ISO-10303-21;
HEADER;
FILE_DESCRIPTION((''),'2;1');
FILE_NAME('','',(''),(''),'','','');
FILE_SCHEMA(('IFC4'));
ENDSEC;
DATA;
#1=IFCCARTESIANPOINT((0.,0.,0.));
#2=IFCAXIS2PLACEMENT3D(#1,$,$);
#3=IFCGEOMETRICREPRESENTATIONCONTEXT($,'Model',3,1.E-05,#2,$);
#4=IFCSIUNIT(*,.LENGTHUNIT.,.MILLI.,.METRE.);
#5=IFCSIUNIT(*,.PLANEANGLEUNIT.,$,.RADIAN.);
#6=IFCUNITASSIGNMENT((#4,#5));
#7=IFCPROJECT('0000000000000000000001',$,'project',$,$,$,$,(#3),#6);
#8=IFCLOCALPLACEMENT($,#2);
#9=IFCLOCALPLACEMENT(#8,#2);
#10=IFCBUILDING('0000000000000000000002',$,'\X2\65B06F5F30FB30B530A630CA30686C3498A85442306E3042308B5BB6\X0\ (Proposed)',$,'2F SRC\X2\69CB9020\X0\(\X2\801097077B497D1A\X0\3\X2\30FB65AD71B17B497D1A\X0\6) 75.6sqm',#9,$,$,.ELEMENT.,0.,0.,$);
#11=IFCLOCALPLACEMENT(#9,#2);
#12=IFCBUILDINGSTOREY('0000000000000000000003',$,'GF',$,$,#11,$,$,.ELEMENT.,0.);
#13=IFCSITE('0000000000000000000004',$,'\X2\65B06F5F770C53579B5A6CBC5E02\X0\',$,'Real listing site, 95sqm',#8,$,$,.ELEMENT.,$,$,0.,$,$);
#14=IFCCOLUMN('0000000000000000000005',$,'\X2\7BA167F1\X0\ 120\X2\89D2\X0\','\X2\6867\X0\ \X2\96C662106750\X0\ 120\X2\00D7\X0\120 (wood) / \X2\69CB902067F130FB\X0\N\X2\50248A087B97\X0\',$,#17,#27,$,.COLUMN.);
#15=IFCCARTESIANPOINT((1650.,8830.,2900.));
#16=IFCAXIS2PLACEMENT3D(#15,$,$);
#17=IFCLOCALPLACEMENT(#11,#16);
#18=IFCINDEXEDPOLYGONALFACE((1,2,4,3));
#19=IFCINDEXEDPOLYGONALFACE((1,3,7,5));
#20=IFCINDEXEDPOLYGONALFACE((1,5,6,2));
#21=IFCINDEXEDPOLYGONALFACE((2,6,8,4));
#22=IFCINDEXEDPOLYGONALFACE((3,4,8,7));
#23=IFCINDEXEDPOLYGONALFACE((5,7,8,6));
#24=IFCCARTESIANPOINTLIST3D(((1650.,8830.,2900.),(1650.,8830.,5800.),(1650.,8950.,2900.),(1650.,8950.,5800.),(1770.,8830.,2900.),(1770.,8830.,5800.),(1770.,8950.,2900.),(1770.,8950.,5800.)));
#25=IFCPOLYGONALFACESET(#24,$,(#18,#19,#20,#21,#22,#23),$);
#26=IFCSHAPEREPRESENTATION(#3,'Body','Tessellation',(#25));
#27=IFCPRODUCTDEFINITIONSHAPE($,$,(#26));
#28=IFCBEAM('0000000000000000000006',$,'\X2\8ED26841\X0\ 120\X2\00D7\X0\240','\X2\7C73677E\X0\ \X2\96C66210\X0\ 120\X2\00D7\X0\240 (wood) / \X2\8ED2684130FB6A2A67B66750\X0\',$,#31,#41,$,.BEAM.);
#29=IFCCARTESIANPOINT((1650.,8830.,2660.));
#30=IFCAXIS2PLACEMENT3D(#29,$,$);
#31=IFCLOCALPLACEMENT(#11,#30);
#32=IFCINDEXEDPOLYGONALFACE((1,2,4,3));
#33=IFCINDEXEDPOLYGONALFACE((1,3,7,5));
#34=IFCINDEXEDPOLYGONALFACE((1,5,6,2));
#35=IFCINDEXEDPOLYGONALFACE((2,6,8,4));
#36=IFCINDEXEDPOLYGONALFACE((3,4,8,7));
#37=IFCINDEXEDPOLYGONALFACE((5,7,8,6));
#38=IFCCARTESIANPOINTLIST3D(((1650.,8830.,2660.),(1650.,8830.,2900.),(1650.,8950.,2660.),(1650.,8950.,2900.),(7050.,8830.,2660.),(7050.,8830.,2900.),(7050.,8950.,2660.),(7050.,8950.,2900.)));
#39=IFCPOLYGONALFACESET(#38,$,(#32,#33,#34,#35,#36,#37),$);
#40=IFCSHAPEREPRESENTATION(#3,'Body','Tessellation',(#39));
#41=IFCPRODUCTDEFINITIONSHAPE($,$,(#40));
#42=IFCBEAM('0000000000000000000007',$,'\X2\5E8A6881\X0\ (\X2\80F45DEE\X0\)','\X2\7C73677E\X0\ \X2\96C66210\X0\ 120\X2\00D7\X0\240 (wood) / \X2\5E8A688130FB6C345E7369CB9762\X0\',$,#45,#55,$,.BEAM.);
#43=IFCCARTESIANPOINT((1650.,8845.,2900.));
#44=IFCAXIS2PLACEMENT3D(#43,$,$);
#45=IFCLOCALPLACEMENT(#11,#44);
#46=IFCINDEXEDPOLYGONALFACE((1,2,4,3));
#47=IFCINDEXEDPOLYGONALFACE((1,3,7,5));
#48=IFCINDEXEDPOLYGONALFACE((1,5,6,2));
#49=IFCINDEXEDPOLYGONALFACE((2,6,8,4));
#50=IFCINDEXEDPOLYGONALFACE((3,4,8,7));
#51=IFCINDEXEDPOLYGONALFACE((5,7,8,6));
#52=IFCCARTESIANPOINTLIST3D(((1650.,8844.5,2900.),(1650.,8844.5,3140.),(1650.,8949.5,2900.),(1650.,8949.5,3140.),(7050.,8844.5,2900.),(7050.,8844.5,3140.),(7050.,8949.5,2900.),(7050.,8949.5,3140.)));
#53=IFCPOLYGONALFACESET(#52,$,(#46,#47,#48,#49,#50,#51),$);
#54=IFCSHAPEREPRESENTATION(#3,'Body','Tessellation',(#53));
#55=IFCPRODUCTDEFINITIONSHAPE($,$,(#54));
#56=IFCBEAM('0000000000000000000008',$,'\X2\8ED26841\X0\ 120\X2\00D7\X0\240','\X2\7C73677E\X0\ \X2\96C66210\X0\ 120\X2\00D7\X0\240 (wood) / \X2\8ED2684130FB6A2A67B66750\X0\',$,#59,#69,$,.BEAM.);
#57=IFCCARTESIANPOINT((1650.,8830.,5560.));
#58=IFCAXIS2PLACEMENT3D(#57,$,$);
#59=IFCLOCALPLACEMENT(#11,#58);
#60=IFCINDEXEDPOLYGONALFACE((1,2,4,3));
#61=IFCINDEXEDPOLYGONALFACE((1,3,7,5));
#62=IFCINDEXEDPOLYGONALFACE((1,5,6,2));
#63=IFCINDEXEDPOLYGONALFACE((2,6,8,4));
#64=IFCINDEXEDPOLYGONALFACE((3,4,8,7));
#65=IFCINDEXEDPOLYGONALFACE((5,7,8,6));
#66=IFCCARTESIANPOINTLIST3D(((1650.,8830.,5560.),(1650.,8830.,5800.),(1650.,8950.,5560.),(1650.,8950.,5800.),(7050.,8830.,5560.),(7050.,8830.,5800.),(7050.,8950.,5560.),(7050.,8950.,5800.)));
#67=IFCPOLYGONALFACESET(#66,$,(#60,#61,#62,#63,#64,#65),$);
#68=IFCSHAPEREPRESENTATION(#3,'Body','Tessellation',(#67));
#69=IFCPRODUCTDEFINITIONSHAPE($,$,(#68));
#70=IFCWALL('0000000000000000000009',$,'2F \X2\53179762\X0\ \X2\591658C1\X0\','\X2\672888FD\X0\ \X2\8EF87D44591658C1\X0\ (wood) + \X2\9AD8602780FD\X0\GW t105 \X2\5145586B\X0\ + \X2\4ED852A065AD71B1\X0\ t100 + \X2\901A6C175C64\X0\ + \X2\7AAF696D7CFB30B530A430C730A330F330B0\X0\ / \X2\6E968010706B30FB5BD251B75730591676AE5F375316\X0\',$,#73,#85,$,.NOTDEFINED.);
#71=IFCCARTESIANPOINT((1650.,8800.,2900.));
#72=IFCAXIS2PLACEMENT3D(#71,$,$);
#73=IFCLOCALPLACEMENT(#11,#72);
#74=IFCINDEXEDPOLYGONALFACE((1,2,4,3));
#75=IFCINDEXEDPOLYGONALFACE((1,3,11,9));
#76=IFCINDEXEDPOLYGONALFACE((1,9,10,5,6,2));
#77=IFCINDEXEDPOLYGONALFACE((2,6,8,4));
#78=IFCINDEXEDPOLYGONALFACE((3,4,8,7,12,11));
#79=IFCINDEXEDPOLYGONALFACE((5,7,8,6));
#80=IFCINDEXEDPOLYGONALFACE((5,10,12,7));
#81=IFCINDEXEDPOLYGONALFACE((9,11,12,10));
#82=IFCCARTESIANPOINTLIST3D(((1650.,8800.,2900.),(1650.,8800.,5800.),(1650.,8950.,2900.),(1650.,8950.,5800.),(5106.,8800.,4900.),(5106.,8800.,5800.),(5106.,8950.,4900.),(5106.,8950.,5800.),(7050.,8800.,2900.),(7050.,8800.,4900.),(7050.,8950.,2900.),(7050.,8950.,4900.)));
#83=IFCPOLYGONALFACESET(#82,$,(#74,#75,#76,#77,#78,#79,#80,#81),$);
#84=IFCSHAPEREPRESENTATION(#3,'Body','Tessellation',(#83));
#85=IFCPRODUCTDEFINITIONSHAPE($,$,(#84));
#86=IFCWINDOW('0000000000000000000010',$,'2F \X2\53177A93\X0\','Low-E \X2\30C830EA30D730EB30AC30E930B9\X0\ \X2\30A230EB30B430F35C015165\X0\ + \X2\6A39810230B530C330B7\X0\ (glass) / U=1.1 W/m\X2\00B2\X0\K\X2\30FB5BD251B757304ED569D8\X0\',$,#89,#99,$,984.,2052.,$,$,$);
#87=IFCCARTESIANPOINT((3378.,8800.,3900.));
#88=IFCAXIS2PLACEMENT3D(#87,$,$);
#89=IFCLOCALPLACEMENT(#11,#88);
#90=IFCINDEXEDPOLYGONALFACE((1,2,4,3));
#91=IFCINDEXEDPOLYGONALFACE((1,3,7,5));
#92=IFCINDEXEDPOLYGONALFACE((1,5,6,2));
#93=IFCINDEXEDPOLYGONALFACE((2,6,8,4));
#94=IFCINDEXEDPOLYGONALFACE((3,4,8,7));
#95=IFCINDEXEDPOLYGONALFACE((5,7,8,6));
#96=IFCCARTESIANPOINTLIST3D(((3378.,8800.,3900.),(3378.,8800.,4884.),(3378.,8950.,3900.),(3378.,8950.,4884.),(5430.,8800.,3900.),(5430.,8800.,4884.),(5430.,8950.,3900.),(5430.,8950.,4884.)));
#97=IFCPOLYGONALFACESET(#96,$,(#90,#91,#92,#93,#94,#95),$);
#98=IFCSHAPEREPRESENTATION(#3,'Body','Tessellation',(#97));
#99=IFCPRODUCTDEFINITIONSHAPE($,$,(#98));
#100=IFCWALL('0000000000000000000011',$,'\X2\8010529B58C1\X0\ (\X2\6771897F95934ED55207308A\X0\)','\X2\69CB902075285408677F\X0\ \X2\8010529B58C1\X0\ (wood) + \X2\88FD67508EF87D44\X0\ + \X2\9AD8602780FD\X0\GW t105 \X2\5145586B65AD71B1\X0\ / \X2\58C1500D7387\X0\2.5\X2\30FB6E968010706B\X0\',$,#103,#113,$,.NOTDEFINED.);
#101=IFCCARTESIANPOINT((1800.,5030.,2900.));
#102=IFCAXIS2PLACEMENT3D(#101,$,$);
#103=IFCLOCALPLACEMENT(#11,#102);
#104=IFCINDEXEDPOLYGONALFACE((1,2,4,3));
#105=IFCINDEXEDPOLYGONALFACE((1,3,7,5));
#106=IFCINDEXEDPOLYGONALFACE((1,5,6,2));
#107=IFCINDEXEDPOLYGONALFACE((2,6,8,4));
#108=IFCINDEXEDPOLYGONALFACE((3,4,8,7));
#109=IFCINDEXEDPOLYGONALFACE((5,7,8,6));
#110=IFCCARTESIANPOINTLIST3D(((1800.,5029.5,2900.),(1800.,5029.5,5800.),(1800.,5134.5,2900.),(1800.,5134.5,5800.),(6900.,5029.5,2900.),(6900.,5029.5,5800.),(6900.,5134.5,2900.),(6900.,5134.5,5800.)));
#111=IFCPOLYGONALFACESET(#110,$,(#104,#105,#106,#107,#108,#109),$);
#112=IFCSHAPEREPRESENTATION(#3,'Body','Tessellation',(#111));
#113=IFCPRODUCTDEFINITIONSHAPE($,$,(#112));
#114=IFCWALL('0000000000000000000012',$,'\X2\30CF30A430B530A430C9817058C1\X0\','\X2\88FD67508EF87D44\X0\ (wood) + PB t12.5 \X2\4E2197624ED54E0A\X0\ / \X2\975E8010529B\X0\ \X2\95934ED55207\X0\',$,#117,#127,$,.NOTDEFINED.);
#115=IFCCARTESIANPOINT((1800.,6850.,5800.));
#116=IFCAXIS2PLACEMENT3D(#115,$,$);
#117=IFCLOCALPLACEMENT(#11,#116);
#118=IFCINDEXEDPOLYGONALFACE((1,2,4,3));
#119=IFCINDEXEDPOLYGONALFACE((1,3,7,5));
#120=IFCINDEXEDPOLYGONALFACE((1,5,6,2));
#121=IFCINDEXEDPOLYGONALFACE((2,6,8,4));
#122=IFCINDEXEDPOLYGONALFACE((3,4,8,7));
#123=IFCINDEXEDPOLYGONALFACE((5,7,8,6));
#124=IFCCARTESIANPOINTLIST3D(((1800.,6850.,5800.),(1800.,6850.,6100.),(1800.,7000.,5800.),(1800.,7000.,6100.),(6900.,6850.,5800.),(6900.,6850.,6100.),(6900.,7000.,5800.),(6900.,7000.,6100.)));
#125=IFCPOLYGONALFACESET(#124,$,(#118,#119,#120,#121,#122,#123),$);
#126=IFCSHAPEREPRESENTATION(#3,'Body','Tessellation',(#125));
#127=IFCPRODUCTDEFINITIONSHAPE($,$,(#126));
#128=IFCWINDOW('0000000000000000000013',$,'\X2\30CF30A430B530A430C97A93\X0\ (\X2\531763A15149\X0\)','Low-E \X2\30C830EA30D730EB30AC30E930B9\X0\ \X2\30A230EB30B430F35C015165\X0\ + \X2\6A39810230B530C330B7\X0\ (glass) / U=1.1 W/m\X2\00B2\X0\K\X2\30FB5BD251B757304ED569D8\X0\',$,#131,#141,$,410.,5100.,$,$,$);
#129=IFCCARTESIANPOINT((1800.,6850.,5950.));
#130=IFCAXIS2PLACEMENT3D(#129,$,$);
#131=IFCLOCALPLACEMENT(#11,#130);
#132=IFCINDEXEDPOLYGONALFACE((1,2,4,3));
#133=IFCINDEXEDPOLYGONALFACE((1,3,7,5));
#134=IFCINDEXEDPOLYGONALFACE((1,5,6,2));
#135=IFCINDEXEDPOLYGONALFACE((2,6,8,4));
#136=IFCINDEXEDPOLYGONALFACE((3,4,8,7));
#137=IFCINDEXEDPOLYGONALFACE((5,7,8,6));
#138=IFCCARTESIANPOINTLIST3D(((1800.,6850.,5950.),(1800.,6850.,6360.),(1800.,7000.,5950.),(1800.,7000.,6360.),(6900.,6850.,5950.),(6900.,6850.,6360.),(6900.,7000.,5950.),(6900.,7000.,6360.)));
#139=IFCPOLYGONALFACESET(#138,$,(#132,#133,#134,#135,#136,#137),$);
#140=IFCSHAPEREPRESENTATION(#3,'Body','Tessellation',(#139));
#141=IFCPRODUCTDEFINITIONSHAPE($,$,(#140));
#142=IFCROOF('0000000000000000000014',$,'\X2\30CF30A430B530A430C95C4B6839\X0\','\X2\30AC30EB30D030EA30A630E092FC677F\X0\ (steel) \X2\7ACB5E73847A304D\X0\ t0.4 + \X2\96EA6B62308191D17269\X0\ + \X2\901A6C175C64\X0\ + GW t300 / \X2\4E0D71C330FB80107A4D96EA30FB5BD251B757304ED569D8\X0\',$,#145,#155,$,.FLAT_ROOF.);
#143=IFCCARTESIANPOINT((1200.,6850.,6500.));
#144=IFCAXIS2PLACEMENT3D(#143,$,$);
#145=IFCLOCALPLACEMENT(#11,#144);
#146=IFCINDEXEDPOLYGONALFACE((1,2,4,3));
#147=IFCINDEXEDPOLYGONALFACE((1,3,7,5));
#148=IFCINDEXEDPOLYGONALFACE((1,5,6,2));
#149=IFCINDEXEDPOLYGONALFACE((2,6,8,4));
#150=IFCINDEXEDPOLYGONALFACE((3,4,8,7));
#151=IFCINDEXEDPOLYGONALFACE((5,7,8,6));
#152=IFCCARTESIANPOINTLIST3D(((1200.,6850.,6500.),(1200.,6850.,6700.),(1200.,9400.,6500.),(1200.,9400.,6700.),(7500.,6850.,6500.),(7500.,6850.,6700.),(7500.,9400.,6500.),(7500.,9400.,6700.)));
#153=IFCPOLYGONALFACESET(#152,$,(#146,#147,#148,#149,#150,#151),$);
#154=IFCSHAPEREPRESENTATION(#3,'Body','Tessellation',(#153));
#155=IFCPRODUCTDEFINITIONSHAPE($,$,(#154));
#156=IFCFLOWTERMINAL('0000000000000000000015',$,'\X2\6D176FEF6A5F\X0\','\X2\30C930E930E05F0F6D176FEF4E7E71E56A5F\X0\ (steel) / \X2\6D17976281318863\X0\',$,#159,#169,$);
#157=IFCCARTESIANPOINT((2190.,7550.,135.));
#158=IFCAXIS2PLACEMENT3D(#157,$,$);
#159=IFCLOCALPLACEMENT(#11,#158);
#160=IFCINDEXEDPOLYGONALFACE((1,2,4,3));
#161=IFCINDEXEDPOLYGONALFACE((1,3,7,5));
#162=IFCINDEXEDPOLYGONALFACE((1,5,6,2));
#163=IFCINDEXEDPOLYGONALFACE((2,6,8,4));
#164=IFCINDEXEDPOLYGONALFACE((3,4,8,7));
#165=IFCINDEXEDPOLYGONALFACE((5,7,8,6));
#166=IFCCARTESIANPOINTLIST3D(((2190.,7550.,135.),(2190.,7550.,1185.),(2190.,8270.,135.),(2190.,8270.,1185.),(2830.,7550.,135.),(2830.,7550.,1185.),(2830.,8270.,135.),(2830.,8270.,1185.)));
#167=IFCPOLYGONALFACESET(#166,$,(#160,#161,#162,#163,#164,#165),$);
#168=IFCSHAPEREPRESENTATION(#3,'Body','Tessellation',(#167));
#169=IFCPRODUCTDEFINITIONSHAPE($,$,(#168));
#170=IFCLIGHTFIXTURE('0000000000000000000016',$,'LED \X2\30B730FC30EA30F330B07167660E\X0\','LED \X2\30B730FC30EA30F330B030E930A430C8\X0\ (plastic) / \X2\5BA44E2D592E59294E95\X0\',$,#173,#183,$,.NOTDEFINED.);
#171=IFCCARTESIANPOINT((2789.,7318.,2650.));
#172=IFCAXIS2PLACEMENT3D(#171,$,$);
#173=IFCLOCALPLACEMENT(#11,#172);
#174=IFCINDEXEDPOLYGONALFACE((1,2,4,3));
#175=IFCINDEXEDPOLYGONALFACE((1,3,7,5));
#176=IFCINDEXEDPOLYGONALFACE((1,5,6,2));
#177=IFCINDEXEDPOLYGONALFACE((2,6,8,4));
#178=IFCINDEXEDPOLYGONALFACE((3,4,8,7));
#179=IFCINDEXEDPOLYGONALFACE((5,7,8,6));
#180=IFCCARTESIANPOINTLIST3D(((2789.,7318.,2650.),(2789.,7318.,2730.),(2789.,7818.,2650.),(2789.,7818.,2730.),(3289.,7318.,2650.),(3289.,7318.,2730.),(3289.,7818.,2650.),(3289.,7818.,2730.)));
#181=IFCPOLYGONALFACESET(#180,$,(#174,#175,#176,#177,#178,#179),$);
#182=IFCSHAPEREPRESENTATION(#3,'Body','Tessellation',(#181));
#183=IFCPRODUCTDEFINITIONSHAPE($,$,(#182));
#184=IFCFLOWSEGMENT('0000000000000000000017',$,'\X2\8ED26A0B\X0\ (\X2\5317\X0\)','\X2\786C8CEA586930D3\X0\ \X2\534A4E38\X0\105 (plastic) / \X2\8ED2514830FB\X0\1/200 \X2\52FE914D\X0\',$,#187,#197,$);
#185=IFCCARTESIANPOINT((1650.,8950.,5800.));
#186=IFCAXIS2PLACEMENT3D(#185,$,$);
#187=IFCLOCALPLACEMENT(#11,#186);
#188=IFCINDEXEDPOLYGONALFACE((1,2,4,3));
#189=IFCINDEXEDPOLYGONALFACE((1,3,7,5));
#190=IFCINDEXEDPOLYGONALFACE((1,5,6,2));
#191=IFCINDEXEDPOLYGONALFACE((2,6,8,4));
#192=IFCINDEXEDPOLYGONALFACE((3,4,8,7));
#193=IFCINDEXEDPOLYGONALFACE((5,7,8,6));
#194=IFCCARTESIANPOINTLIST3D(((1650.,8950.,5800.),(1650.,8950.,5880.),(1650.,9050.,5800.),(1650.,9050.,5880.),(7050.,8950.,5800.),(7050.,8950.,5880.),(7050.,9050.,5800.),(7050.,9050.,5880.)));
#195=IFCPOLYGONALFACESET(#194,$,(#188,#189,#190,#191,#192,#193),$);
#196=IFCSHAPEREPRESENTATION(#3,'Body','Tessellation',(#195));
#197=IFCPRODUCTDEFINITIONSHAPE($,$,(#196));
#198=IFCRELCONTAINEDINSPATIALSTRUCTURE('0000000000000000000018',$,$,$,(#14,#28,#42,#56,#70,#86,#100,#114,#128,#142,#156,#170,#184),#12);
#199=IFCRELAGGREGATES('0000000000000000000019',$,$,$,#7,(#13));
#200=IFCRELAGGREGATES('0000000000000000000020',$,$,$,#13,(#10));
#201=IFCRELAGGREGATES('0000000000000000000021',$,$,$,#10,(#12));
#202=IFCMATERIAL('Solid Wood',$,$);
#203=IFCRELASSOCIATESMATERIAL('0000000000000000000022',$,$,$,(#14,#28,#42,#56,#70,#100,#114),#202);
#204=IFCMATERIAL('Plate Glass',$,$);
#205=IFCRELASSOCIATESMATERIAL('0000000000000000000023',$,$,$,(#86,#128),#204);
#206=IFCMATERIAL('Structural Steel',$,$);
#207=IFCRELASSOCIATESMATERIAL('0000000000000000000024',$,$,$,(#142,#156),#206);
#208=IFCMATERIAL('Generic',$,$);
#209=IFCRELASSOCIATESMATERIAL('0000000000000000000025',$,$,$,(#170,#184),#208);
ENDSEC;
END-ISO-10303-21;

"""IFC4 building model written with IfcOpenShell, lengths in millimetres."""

from ifc_helpers import new_model, si_unit, frame, frame_2d, origin, place, context, project, spatial, rectangle, extrude, material, element, fill, save


model = new_model("IFC4")

# Units and contexts
model_context = context("Model", 3, precision=1e-05, world=origin())
ifc_project = project(units=[si_unit("LENGTHUNIT", "METRE", prefix="MILLI"), si_unit("PLANEANGLEUNIT", "RADIAN")], contexts=[model_context])

# Site, building, storey
site_placement = place(None, origin())
site = spatial("IfcSite", under=ifc_project, at=site_placement, Name="新潟県南魚沼市", ObjectType="Real listing site, 95sqm", CompositionType="ELEMENT", RefElevation=0.0)
building_placement = place(site_placement, origin())
building = spatial("IfcBuilding", under=site, at=building_placement, Name="新潟・サウナと水風呂のある家 (Proposed)", ObjectType="2F SRC構造(耐震等級3・断熱等級6) 75.6sqm", CompositionType="ELEMENT", ElevationOfRefHeight=0.0, ElevationOfTerrain=0.0)
storey_placement = place(building_placement, origin())
storey = spatial("IfcBuildingStorey", under=building, at=storey_placement, Name="GF", CompositionType="ELEMENT", Elevation=0.0)

# Column
ifc_material_1 = material(Name="Solid Wood")
column_1_placement = place(storey_placement, frame((1650.0, 8830.0, 2900.0)))
element("IfcColumn", 1, at=column_1_placement, inside=storey, material=ifc_material_1, Name="管柱 120角", Description="桧 集成材 120×120 (wood) / 構造柱・N値計算", PredefinedType="COLUMN", context=model_context, shape_type="SweptSolid", body=[
    extrude(rectangle(XDim=120.0, YDim=120.0, at=frame_2d((60.0, 60.0))), frame((1650.0, 8830.0, 2900.0)), (0.0, 0.0, 1.0), 2900.0),
])

# Beams
beam_1_placement = place(storey_placement, frame((1650.0, 8830.0, 2660.0)))
element("IfcBeam", 2, at=beam_1_placement, inside=storey, material=ifc_material_1, Name="軒桁 120×240", Description="米松 集成 120×240 (wood) / 軒桁・横架材", PredefinedType="BEAM", context=model_context, shape_type="SweptSolid", body=[
    extrude(rectangle(XDim=5400.0, YDim=120.0, at=frame_2d((2700.0, 60.0))), frame((1650.0, 8830.0, 2660.0)), (0.0, 0.0, 1.0), 240.0),
])
beam_2_placement = place(storey_placement, frame((1650.0, 8845.0, 2900.0)))
element("IfcBeam", 3, at=beam_2_placement, inside=storey, material=ifc_material_1, Name="床梁 (胴差)", Description="米松 集成 120×240 (wood) / 床梁・水平構面", PredefinedType="BEAM", context=model_context, shape_type="SweptSolid", body=[
    extrude(rectangle(XDim=5400.0, YDim=105.0, at=frame_2d((2700.0, 52.0))), frame((1650.0, 8845.0, 2900.0)), (0.0, 0.0, 1.0), 240.0),
])
beam_3_placement = place(storey_placement, frame((1650.0, 8830.0, 5560.0)))
element("IfcBeam", 4, at=beam_3_placement, inside=storey, material=ifc_material_1, Name="軒桁 120×240", Description="米松 集成 120×240 (wood) / 軒桁・横架材", PredefinedType="BEAM", context=model_context, shape_type="SweptSolid", body=[
    extrude(rectangle(XDim=5400.0, YDim=120.0, at=frame_2d((2700.0, 60.0))), frame((1650.0, 8830.0, 5560.0)), (0.0, 0.0, 1.0), 240.0),
])

# Wall, opening, window
wall_1_placement = place(storey_placement, frame((1650.0, 8800.0, 2900.0)))
wall_1 = element("IfcWall", 5, at=wall_1_placement, inside=storey, material=ifc_material_1, Name="2F 北面 外壁", Description="木製 軸組外壁 (wood) + 高性能GW t105 充填 + 付加断熱 t100 + 通気層 + 窯業系サイディング / 準耐火・寒冷地外皮強化", PredefinedType="NOTDEFINED", context=model_context, shape_type="SweptSolid", body=[
    extrude(rectangle(XDim=5400.0, YDim=150.0, at=frame_2d((2700.0, 75.0))), frame((1650.0, 8800.0, 2900.0)), (0.0, 0.0, 1.0), 2900.0),
])
opening_1_placement = place(storey_placement, frame((3378.0, 8800.0, 3900.0)))
opening_1 = element("IfcOpeningElement", 6, at=opening_1_placement, cuts=wall_1, PredefinedType="NOTDEFINED", context=model_context, shape_type="SweptSolid", body=[
    extrude(rectangle(XDim=2052.0, YDim=150.0, at=frame_2d((1026.0, 75.0))), frame((3378.0, 8800.0, 3900.0)), (0.0, 0.0, 1.0), 984.0),
])
ifc_material_2 = material(Name="Plate Glass")
window_1_placement = place(storey_placement, frame((3378.0, 8800.0, 3900.0)))
window_1 = element("IfcWindow", 7, at=window_1_placement, inside=storey, material=ifc_material_2, Name="2F 北窓", Description="Low-E トリプルガラス アルゴン封入 + 樹脂サッシ (glass) / U=1.1 W/m²K・寒冷地仕様", OverallHeight=984.0, OverallWidth=2052.0, context=model_context, shape_type="SweptSolid", body=[
    extrude(rectangle(XDim=2052.0, YDim=150.0, at=frame_2d((1026.0, 75.0))), frame((3378.0, 8800.0, 3900.0)), (0.0, 0.0, 1.0), 984.0),
])
fill(opening_1, window_1)

# Wall
wall_2_placement = place(storey_placement, frame((1800.0, 5030.0, 2900.0)))
element("IfcWall", 8, at=wall_2_placement, inside=storey, material=ifc_material_1, Name="耐力壁 (東西間仕切り)", Description="構造用合板 耐力壁 (wood) + 製材軸組 + 高性能GW t105 充填断熱 / 壁倍率2.5・準耐火", PredefinedType="NOTDEFINED", context=model_context, shape_type="SweptSolid", body=[
    extrude(rectangle(XDim=5100.0, YDim=105.0, at=frame_2d((2550.0, 52.0))), frame((1800.0, 5030.0, 2900.0)), (0.0, 0.0, 1.0), 2900.0),
])

# Wall, opening, window
wall_3_placement = place(storey_placement, frame((1800.0, 6850.0, 5800.0)))
wall_3 = element("IfcWall", 9, at=wall_3_placement, inside=storey, material=ifc_material_1, Name="ハイサイド腰壁", Description="製材軸組 (wood) + PB t12.5 両面仕上 / 非耐力 間仕切", PredefinedType="NOTDEFINED", context=model_context, shape_type="SweptSolid", body=[
    extrude(rectangle(XDim=5100.0, YDim=150.0, at=frame_2d((2550.0, 75.0))), frame((1800.0, 6850.0, 5800.0)), (0.0, 0.0, 1.0), 700.0),
])
opening_2_placement = place(storey_placement, frame((1800.0, 6850.0, 5950.0)))
opening_2 = element("IfcOpeningElement", 10, at=opening_2_placement, cuts=wall_3, PredefinedType="NOTDEFINED", context=model_context, shape_type="SweptSolid", body=[
    extrude(rectangle(XDim=5100.0, YDim=150.0, at=frame_2d((2550.0, 75.0))), frame((1800.0, 6850.0, 5950.0)), (0.0, 0.0, 1.0), 410.0),
])
window_2_placement = place(storey_placement, frame((1800.0, 6850.0, 5950.0)))
window_2 = element("IfcWindow", 11, at=window_2_placement, inside=storey, material=ifc_material_2, Name="ハイサイド窓 (北採光)", Description="Low-E トリプルガラス アルゴン封入 + 樹脂サッシ (glass) / U=1.1 W/m²K・寒冷地仕様", OverallHeight=410.0, OverallWidth=5100.0, context=model_context, shape_type="SweptSolid", body=[
    extrude(rectangle(XDim=5100.0, YDim=150.0, at=frame_2d((2550.0, 75.0))), frame((1800.0, 6850.0, 5950.0)), (0.0, 0.0, 1.0), 410.0),
])
fill(opening_2, window_2)

# Roof
ifc_material_3 = material(Name="Structural Steel")
roof_placement = place(storey_placement, frame((1200.0, 6850.0, 6500.0)))
element("IfcRoof", 12, at=roof_placement, inside=storey, material=ifc_material_3, Name="ハイサイド屋根", Description="ガルバリウム鋼板 (steel) 立平葺き t0.4 + 雪止め金物 + 通気層 + GW t300 / 不燃・耐積雪・寒冷地仕様", PredefinedType="FLAT_ROOF", context=model_context, shape_type="SweptSolid", body=[
    extrude(rectangle(XDim=6300.0, YDim=2550.0, at=frame_2d((3150.0, 1275.0))), frame((1200.0, 6850.0, 6500.0)), (0.0, 0.0, 1.0), 200.0),
])

# Flow terminal
flow_terminal_placement = place(storey_placement, frame((2190.0, 7550.0, 135.0)))
element("IfcFlowTerminal", 13, at=flow_terminal_placement, inside=storey, material=ifc_material_3, Name="洗濯機", Description="ドラム式洗濯乾燥機 (steel) / 洗面脱衣", context=model_context, shape_type="SweptSolid", body=[
    extrude(rectangle(XDim=640.0, YDim=720.0, at=frame_2d((320.0, 360.0))), frame((2190.0, 7550.0, 135.0)), (0.0, 0.0, 1.0), 1050.0),
])

# Light fixture
ifc_material_4 = material(Name="Generic")
light_fixture_placement = place(storey_placement, frame((2789.0, 7318.0, 2650.0)))
element("IfcLightFixture", 14, at=light_fixture_placement, inside=storey, material=ifc_material_4, Name="LED シーリング照明", Description="LED シーリングライト (plastic) / 室中央天井", PredefinedType="NOTDEFINED", context=model_context, shape_type="SweptSolid", body=[
    extrude(rectangle(XDim=500.0, YDim=500.0, at=frame_2d((250.0, 250.0))), frame((2789.0, 7318.0, 2650.0)), (0.0, 0.0, 1.0), 80.0),
])

# Flow segment
flow_segment_placement = place(storey_placement, frame((1650.0, 8950.0, 5800.0)))
element("IfcFlowSegment", 15, at=flow_segment_placement, inside=storey, material=ifc_material_4, Name="軒樋 (北)", Description="硬質塩ビ 半丸105 (plastic) / 軒先・1/200 勾配", context=model_context, shape_type="SweptSolid", body=[
    extrude(rectangle(XDim=5400.0, YDim=100.0, at=frame_2d((2700.0, 50.0))), frame((1650.0, 8950.0, 5800.0)), (0.0, 0.0, 1.0), 80.0),
])

save(model, "model.ifc")
